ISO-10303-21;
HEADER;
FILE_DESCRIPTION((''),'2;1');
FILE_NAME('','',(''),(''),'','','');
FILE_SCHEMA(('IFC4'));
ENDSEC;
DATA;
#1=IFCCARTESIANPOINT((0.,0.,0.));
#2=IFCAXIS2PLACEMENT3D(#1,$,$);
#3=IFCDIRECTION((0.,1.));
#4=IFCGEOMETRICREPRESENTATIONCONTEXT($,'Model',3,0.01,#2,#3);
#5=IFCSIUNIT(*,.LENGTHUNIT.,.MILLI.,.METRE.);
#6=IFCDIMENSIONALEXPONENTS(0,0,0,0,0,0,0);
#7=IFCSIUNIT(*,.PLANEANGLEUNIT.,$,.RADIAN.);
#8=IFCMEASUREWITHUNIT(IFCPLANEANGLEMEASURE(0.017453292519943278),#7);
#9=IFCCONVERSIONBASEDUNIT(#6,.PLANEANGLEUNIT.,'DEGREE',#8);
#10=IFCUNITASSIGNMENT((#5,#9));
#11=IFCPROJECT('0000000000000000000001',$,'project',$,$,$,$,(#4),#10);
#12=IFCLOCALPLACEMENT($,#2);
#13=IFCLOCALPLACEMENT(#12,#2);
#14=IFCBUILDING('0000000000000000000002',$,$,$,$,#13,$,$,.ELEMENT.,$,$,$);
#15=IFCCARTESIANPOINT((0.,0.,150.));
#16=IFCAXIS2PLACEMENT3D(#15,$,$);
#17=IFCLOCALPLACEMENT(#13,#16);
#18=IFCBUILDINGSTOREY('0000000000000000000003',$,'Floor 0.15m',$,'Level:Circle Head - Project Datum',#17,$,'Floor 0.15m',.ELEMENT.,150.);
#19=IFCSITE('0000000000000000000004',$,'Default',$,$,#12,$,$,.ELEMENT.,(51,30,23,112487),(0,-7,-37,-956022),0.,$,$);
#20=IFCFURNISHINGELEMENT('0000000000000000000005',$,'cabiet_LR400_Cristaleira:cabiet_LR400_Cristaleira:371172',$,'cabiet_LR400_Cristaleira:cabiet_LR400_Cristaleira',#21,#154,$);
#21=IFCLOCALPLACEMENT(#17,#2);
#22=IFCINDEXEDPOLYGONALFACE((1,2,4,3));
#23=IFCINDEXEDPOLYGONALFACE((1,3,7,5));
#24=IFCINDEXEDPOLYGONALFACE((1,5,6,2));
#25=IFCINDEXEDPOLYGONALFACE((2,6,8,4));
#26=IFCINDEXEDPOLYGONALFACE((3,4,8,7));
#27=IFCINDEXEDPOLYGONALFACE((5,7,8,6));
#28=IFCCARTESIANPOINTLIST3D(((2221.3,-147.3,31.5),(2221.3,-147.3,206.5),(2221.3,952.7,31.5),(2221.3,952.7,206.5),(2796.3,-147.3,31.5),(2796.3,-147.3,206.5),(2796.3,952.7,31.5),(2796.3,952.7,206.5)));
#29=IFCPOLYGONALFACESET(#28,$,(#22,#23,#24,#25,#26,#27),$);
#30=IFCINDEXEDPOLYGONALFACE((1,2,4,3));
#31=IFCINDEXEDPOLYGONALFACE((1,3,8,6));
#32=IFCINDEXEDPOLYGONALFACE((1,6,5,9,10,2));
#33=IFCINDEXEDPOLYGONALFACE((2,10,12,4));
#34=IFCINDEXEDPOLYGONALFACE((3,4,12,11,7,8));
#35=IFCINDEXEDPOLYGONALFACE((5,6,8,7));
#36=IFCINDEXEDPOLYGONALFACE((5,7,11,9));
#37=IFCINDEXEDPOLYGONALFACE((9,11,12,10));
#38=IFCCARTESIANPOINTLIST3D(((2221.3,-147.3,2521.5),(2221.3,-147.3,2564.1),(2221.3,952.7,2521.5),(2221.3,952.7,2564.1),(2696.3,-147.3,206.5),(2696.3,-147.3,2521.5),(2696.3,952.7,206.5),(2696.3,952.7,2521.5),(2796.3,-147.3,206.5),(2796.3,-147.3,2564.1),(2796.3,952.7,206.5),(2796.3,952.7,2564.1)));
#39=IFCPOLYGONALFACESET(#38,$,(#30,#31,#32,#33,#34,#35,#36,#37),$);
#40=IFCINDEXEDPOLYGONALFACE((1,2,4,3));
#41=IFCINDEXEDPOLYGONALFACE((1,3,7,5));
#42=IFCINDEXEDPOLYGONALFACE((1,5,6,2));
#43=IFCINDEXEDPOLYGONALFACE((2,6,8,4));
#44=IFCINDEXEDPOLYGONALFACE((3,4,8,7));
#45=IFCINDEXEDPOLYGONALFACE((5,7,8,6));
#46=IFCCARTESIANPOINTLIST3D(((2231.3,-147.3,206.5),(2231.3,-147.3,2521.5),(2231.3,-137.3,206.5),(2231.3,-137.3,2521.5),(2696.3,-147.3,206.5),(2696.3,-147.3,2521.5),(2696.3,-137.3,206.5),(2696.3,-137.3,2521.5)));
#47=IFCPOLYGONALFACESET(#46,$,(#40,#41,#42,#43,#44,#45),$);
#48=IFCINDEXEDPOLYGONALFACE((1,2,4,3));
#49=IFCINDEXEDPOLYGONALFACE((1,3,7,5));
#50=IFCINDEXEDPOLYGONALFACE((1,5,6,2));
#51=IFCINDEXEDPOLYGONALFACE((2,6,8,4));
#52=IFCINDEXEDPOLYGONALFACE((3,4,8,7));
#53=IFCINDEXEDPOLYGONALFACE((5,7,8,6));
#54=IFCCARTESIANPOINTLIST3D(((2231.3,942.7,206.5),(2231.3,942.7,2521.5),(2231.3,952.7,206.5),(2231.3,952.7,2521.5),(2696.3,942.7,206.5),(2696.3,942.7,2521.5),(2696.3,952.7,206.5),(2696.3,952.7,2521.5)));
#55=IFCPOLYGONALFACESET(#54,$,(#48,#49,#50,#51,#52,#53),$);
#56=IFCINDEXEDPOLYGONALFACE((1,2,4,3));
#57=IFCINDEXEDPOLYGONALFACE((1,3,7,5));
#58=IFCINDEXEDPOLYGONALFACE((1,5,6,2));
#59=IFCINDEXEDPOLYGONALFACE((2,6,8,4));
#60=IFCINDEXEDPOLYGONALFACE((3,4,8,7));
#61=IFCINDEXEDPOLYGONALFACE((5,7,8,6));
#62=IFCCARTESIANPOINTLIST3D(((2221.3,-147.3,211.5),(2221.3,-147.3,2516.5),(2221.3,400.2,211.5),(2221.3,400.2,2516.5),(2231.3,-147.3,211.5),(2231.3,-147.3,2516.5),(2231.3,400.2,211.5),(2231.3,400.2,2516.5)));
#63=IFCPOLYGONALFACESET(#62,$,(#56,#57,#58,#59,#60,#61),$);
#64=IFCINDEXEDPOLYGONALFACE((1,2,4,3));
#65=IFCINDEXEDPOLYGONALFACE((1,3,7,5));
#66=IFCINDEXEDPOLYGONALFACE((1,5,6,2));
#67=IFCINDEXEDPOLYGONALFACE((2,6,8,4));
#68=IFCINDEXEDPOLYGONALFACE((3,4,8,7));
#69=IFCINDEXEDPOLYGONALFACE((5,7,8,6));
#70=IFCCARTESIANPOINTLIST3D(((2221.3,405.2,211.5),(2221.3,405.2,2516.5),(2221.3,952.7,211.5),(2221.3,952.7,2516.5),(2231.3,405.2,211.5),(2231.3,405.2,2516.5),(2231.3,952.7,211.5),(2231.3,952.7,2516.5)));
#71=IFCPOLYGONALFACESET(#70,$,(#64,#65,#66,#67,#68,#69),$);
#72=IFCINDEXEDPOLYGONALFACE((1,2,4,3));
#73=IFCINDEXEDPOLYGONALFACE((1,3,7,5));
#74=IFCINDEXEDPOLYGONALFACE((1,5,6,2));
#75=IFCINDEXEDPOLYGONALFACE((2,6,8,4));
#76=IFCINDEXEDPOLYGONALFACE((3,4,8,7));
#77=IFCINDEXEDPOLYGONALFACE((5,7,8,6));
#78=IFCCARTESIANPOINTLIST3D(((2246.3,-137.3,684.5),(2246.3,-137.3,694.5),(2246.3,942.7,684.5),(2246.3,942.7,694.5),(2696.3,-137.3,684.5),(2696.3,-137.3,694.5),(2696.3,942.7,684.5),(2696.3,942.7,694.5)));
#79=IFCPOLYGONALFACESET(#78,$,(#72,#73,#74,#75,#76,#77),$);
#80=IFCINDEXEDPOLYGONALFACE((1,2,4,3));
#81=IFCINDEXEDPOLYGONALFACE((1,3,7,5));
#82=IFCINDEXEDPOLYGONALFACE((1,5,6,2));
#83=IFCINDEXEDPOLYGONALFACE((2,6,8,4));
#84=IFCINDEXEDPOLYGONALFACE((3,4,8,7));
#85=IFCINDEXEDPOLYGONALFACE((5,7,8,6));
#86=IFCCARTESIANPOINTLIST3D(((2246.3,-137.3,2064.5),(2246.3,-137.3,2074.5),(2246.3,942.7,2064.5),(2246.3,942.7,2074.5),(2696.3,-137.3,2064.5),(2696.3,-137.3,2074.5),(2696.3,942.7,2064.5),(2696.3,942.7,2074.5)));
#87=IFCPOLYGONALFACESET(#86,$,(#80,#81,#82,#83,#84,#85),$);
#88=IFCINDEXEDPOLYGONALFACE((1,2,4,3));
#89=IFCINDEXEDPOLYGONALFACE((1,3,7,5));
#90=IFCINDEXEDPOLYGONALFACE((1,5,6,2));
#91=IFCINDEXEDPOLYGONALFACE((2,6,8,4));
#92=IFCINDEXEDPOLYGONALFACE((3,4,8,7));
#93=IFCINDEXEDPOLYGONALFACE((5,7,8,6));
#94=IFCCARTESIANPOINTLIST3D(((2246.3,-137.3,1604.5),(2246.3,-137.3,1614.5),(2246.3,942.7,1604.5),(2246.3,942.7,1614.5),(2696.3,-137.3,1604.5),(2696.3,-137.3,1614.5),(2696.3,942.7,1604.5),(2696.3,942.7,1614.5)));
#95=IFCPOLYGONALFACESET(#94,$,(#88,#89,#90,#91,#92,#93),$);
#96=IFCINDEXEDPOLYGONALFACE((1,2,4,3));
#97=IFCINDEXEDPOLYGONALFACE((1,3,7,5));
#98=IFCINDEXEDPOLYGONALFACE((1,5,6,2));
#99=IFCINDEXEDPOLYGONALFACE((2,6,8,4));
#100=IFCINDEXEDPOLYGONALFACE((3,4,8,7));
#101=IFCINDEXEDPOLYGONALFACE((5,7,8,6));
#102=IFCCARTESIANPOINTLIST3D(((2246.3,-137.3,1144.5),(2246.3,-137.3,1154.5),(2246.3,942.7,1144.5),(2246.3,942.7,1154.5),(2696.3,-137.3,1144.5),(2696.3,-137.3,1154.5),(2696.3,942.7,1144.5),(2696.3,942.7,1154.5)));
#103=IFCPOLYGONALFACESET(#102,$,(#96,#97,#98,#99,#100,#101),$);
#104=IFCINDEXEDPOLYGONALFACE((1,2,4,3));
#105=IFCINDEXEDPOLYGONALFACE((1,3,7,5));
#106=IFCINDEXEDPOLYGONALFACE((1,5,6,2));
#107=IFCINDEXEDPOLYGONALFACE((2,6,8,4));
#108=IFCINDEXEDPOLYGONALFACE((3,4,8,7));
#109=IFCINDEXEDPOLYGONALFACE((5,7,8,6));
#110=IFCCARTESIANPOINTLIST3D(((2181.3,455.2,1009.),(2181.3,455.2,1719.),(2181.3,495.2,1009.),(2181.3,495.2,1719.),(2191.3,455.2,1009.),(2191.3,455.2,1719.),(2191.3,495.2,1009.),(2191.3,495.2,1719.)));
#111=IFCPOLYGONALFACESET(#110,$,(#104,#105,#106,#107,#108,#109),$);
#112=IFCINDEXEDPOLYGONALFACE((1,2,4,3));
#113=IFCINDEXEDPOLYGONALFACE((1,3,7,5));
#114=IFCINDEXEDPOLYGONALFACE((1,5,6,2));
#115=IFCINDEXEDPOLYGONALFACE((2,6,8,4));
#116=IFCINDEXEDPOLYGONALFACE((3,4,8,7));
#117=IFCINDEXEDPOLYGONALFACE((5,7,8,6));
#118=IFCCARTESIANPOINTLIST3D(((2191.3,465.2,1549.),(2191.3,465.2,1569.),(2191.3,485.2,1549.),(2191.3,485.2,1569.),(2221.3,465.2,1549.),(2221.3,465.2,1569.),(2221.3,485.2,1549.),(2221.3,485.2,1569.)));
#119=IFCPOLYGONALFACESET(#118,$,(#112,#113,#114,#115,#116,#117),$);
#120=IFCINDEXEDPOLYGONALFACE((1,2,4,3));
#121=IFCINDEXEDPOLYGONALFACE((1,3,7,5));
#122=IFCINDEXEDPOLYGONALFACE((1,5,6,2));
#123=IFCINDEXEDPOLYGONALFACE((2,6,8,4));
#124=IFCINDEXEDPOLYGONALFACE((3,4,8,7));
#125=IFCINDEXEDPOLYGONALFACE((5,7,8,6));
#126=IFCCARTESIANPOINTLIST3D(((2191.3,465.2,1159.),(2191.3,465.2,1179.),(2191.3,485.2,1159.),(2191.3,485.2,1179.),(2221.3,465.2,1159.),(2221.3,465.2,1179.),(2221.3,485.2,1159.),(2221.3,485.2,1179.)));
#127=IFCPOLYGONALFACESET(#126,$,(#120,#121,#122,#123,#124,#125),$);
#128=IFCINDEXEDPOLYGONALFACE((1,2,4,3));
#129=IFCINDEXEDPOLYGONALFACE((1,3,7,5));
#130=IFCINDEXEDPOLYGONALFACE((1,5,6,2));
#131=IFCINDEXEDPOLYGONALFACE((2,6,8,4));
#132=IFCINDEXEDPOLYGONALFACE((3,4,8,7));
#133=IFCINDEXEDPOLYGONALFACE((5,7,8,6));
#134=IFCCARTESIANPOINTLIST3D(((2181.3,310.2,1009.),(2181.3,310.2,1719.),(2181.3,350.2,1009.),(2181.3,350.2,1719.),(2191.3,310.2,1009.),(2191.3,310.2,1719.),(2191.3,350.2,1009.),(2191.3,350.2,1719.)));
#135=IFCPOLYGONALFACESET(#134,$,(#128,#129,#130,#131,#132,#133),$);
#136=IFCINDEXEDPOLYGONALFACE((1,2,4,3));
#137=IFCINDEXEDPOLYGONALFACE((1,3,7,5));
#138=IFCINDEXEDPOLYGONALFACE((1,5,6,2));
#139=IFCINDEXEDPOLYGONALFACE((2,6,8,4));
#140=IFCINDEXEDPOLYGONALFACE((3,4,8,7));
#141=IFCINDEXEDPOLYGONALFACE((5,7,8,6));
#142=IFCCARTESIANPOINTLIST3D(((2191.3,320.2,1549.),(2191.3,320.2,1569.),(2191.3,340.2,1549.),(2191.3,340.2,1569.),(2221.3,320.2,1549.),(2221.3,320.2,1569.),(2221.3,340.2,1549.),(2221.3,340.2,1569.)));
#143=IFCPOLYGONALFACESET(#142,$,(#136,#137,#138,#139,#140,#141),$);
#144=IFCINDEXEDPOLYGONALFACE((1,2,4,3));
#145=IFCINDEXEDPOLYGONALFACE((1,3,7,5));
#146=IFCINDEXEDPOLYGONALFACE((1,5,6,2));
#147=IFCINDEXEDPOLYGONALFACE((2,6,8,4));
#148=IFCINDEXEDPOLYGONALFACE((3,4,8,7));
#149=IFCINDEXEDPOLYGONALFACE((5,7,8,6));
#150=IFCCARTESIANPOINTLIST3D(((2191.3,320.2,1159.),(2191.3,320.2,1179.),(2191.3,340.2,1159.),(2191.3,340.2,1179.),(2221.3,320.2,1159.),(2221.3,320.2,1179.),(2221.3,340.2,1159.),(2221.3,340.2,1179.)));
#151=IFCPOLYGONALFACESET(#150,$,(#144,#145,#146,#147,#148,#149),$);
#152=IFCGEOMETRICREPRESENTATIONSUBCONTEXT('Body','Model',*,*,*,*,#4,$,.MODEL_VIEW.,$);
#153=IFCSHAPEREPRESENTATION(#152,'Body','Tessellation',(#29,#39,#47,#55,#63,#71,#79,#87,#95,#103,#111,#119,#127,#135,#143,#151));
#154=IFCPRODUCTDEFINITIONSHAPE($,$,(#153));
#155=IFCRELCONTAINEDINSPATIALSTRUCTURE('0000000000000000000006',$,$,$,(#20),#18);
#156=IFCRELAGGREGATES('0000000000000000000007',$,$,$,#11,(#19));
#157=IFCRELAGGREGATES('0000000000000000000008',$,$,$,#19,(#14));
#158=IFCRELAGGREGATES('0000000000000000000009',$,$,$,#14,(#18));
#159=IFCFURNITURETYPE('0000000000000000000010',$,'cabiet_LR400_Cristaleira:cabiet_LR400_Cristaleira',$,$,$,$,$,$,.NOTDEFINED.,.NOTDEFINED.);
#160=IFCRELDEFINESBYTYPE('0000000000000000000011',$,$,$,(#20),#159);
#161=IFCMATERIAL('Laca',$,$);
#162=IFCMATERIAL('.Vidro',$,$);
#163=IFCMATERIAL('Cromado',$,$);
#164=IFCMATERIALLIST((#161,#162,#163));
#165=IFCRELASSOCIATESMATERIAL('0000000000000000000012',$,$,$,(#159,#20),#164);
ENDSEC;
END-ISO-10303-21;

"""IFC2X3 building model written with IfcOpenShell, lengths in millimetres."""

from ifc_helpers import new_model, entity, si_unit, converted_unit, direction, frame, frame_2d, origin, origin_2d_with_axis, place, context, subcontext, project, spatial, polyline, rectangle, outline, extrude, source, transform, mapped, material, material_list, type_object, type_shapes, element, save


model = new_model("IFC2X3")

# Units and contexts
model_context = context("Model", 3, precision=0.01, world=origin(), true_north=direction((0.0, 1.0)))
body_context = subcontext(model_context, "Body", "Model", "MODEL_VIEW")
ifc_project = project(units=[si_unit("LENGTHUNIT", "METRE", prefix="MILLI"), converted_unit("PLANEANGLEUNIT", "DEGREE", entity("IfcPlaneAngleMeasure", 0.017453292519943278), si_unit("PLANEANGLEUNIT", "RADIAN"), dimensions=[0, 0, 0, 0, 0, 0, 0])], contexts=[model_context])

# Site, building, storey
site_placement = place(None, origin())
site = spatial("IfcSite", under=ifc_project, at=site_placement, Name="Default", CompositionType="ELEMENT", RefLatitude=(51, 30, 23, 112487), RefLongitude=(0, -7, -37, -956022), RefElevation=0.0)
building_placement = place(site_placement, origin())
building = spatial("IfcBuilding", under=site, at=building_placement, CompositionType="ELEMENT")
storey_placement = place(building_placement, frame((0.0, 0.0, 150.0)))
storey = spatial("IfcBuildingStorey", under=building, at=storey_placement, Name="Floor 0.15m", ObjectType="Level:Circle Head - Project Datum", LongName="Floor 0.15m", CompositionType="ELEMENT", Elevation=150.0)

# Furnishing element
ifc_material_1 = material(Name="Laca")
ifc_material_2 = material(Name=".Vidro")
ifc_material_3 = material(Name="Cromado")
ifc_material_list = material_list([ifc_material_1, ifc_material_2, ifc_material_3])
furniture_type_1 = type_object("IfcFurnitureType", Name="cabiet_LR400_Cristaleira:cabiet_LR400_Cristaleira", AssemblyPlace="NOTDEFINED", material=ifc_material_list)
shared_shape_1 = source(origin(), body_context, "Body", "SweptSolid", [
    extrude(rectangle(XDim=575.0, YDim=1100.0, at=origin_2d_with_axis()), frame((287.5, 550.0, 31.5), z_axis=(0.0, 0.0, 1.0), x_axis=(-1.0, 0.0, 0.0)), (0.0, 0.0, 1.0), 175.0),
    extrude(outline(polyline([(-225.0, -800.1), (350.0, -800.1), (350.0, -757.5), (-125.0, -757.5), (-125.0, 1557.5), (-225.0, 1557.5), (-225.0, -800.1)])), frame((225.0, 0.0, 1764.1), z_axis=(0.0, 1.0, 0.0), x_axis=(1.0, 0.0, 0.0)), (0.0, 0.0, 1.0), 1100.0),
    extrude(rectangle(XDim=465.0, YDim=10.0, at=origin_2d_with_axis()), frame((332.5, 1095.0, 206.5), z_axis=(0.0, 0.0, 1.0), x_axis=(-1.0, 0.0, 0.0)), (0.0, 0.0, 1.0), 2315.0),
    extrude(rectangle(XDim=10.0, YDim=465.0, at=origin_2d_with_axis()), frame((332.5, 5.0, 206.5), z_axis=(0.0, 0.0, 1.0), x_axis=(0.0, 1.0, 0.0)), (0.0, 0.0, 1.0), 2315.0),
    extrude(rectangle(XDim=547.5, YDim=10.0, at=origin_2d_with_axis()), frame((570.0, 826.3, 211.5), z_axis=(0.0, 0.0, 1.0), x_axis=(0.0, 1.0, 0.0)), (0.0, 0.0, 1.0), 2305.0),
    extrude(rectangle(XDim=547.5, YDim=10.0, at=origin_2d_with_axis()), frame((570.0, 273.8, 211.5), z_axis=(0.0, 0.0, 1.0), x_axis=(0.0, 1.0, 0.0)), (0.0, 0.0, 1.0), 2305.0),
    extrude(rectangle(XDim=450.0, YDim=1080.0, at=frame_2d((0.0, 0.0), x_axis=(1.0, 0.0))), frame((325.0, 550.0, 684.5), z_axis=(0.0, 0.0, 1.0), x_axis=(-1.0, 0.0, 0.0)), (0.0, 0.0, 1.0), 10.0),
    extrude(rectangle(XDim=450.0, YDim=1080.0, at=frame_2d((0.0, 0.0), x_axis=(1.0, 0.0))), frame((325.0, 550.0, 2064.5), z_axis=(0.0, 0.0, 1.0), x_axis=(-1.0, 0.0, 0.0)), (0.0, 0.0, 1.0), 10.0),
    extrude(rectangle(XDim=450.0, YDim=1080.0, at=frame_2d((0.0, 0.0), x_axis=(1.0, 0.0))), frame((325.0, 550.0, 1604.5), z_axis=(0.0, 0.0, 1.0), x_axis=(-1.0, 0.0, 0.0)), (0.0, 0.0, 1.0), 10.0),
    extrude(rectangle(XDim=450.0, YDim=1080.0, at=frame_2d((0.0, 0.0), x_axis=(1.0, 0.0))), frame((325.0, 550.0, 1144.5), z_axis=(0.0, 0.0, 1.0), x_axis=(-1.0, 0.0, 0.0)), (0.0, 0.0, 1.0), 10.0),
    extrude(rectangle(XDim=10.0, YDim=40.0, at=frame_2d((0.0, 0.0), x_axis=(1.0, 0.0))), frame((610.0, 477.5, 1009.0), z_axis=(0.0, 0.0, 1.0), x_axis=(-1.0, 0.0, 0.0)), (0.0, 0.0, 1.0), 710.0),
    extrude(rectangle(XDim=30.0, YDim=20.0, at=frame_2d((0.0, 0.0), x_axis=(1.0, 0.0))), frame((590.0, 477.5, 1549.0), z_axis=(0.0, 0.0, 1.0), x_axis=(-1.0, 0.0, 0.0)), (0.0, 0.0, 1.0), 20.0),
    extrude(rectangle(XDim=30.0, YDim=20.0, at=frame_2d((0.0, 0.0), x_axis=(1.0, 0.0))), frame((590.0, 477.5, 1159.0), z_axis=(0.0, 0.0, 1.0), x_axis=(-1.0, 0.0, 0.0)), (0.0, 0.0, 1.0), 20.0),
    extrude(rectangle(XDim=10.0, YDim=40.0, at=frame_2d((0.0, 0.0), x_axis=(1.0, 0.0))), frame((610.0, 622.5, 1009.0), z_axis=(0.0, 0.0, 1.0), x_axis=(-1.0, 0.0, 0.0)), (0.0, 0.0, 1.0), 710.0),
    extrude(rectangle(XDim=30.0, YDim=20.0, at=frame_2d((0.0, 0.0), x_axis=(1.0, 0.0))), frame((590.0, 622.5, 1549.0), z_axis=(0.0, 0.0, 1.0), x_axis=(-1.0, 0.0, 0.0)), (0.0, 0.0, 1.0), 20.0),
    extrude(rectangle(XDim=30.0, YDim=20.0, at=frame_2d((0.0, 0.0), x_axis=(1.0, 0.0))), frame((590.0, 622.5, 1159.0), z_axis=(0.0, 0.0, 1.0), x_axis=(-1.0, 0.0, 0.0)), (0.0, 0.0, 1.0), 20.0),
])
type_shapes(furniture_type_1, [shared_shape_1])
furnishing_1_placement = place(storey_placement, frame((2796.3, 952.7, 0.0), z_axis=(0.0, 0.0, 1.0), x_axis=(-1.0, 0.0, 0.0)))
element("IfcFurnishingElement", 1, at=furnishing_1_placement, inside=storey, type_object=furniture_type_1, material=ifc_material_list, Name="cabiet_LR400_Cristaleira:cabiet_LR400_Cristaleira:371172", ObjectType="cabiet_LR400_Cristaleira:cabiet_LR400_Cristaleira", context=body_context, shape_type="MappedRepresentation", body=[
    mapped(shared_shape_1, transform((0.0, 0.0, 0.0), scale=1.0)),
])

save(model, "model.ifc")
